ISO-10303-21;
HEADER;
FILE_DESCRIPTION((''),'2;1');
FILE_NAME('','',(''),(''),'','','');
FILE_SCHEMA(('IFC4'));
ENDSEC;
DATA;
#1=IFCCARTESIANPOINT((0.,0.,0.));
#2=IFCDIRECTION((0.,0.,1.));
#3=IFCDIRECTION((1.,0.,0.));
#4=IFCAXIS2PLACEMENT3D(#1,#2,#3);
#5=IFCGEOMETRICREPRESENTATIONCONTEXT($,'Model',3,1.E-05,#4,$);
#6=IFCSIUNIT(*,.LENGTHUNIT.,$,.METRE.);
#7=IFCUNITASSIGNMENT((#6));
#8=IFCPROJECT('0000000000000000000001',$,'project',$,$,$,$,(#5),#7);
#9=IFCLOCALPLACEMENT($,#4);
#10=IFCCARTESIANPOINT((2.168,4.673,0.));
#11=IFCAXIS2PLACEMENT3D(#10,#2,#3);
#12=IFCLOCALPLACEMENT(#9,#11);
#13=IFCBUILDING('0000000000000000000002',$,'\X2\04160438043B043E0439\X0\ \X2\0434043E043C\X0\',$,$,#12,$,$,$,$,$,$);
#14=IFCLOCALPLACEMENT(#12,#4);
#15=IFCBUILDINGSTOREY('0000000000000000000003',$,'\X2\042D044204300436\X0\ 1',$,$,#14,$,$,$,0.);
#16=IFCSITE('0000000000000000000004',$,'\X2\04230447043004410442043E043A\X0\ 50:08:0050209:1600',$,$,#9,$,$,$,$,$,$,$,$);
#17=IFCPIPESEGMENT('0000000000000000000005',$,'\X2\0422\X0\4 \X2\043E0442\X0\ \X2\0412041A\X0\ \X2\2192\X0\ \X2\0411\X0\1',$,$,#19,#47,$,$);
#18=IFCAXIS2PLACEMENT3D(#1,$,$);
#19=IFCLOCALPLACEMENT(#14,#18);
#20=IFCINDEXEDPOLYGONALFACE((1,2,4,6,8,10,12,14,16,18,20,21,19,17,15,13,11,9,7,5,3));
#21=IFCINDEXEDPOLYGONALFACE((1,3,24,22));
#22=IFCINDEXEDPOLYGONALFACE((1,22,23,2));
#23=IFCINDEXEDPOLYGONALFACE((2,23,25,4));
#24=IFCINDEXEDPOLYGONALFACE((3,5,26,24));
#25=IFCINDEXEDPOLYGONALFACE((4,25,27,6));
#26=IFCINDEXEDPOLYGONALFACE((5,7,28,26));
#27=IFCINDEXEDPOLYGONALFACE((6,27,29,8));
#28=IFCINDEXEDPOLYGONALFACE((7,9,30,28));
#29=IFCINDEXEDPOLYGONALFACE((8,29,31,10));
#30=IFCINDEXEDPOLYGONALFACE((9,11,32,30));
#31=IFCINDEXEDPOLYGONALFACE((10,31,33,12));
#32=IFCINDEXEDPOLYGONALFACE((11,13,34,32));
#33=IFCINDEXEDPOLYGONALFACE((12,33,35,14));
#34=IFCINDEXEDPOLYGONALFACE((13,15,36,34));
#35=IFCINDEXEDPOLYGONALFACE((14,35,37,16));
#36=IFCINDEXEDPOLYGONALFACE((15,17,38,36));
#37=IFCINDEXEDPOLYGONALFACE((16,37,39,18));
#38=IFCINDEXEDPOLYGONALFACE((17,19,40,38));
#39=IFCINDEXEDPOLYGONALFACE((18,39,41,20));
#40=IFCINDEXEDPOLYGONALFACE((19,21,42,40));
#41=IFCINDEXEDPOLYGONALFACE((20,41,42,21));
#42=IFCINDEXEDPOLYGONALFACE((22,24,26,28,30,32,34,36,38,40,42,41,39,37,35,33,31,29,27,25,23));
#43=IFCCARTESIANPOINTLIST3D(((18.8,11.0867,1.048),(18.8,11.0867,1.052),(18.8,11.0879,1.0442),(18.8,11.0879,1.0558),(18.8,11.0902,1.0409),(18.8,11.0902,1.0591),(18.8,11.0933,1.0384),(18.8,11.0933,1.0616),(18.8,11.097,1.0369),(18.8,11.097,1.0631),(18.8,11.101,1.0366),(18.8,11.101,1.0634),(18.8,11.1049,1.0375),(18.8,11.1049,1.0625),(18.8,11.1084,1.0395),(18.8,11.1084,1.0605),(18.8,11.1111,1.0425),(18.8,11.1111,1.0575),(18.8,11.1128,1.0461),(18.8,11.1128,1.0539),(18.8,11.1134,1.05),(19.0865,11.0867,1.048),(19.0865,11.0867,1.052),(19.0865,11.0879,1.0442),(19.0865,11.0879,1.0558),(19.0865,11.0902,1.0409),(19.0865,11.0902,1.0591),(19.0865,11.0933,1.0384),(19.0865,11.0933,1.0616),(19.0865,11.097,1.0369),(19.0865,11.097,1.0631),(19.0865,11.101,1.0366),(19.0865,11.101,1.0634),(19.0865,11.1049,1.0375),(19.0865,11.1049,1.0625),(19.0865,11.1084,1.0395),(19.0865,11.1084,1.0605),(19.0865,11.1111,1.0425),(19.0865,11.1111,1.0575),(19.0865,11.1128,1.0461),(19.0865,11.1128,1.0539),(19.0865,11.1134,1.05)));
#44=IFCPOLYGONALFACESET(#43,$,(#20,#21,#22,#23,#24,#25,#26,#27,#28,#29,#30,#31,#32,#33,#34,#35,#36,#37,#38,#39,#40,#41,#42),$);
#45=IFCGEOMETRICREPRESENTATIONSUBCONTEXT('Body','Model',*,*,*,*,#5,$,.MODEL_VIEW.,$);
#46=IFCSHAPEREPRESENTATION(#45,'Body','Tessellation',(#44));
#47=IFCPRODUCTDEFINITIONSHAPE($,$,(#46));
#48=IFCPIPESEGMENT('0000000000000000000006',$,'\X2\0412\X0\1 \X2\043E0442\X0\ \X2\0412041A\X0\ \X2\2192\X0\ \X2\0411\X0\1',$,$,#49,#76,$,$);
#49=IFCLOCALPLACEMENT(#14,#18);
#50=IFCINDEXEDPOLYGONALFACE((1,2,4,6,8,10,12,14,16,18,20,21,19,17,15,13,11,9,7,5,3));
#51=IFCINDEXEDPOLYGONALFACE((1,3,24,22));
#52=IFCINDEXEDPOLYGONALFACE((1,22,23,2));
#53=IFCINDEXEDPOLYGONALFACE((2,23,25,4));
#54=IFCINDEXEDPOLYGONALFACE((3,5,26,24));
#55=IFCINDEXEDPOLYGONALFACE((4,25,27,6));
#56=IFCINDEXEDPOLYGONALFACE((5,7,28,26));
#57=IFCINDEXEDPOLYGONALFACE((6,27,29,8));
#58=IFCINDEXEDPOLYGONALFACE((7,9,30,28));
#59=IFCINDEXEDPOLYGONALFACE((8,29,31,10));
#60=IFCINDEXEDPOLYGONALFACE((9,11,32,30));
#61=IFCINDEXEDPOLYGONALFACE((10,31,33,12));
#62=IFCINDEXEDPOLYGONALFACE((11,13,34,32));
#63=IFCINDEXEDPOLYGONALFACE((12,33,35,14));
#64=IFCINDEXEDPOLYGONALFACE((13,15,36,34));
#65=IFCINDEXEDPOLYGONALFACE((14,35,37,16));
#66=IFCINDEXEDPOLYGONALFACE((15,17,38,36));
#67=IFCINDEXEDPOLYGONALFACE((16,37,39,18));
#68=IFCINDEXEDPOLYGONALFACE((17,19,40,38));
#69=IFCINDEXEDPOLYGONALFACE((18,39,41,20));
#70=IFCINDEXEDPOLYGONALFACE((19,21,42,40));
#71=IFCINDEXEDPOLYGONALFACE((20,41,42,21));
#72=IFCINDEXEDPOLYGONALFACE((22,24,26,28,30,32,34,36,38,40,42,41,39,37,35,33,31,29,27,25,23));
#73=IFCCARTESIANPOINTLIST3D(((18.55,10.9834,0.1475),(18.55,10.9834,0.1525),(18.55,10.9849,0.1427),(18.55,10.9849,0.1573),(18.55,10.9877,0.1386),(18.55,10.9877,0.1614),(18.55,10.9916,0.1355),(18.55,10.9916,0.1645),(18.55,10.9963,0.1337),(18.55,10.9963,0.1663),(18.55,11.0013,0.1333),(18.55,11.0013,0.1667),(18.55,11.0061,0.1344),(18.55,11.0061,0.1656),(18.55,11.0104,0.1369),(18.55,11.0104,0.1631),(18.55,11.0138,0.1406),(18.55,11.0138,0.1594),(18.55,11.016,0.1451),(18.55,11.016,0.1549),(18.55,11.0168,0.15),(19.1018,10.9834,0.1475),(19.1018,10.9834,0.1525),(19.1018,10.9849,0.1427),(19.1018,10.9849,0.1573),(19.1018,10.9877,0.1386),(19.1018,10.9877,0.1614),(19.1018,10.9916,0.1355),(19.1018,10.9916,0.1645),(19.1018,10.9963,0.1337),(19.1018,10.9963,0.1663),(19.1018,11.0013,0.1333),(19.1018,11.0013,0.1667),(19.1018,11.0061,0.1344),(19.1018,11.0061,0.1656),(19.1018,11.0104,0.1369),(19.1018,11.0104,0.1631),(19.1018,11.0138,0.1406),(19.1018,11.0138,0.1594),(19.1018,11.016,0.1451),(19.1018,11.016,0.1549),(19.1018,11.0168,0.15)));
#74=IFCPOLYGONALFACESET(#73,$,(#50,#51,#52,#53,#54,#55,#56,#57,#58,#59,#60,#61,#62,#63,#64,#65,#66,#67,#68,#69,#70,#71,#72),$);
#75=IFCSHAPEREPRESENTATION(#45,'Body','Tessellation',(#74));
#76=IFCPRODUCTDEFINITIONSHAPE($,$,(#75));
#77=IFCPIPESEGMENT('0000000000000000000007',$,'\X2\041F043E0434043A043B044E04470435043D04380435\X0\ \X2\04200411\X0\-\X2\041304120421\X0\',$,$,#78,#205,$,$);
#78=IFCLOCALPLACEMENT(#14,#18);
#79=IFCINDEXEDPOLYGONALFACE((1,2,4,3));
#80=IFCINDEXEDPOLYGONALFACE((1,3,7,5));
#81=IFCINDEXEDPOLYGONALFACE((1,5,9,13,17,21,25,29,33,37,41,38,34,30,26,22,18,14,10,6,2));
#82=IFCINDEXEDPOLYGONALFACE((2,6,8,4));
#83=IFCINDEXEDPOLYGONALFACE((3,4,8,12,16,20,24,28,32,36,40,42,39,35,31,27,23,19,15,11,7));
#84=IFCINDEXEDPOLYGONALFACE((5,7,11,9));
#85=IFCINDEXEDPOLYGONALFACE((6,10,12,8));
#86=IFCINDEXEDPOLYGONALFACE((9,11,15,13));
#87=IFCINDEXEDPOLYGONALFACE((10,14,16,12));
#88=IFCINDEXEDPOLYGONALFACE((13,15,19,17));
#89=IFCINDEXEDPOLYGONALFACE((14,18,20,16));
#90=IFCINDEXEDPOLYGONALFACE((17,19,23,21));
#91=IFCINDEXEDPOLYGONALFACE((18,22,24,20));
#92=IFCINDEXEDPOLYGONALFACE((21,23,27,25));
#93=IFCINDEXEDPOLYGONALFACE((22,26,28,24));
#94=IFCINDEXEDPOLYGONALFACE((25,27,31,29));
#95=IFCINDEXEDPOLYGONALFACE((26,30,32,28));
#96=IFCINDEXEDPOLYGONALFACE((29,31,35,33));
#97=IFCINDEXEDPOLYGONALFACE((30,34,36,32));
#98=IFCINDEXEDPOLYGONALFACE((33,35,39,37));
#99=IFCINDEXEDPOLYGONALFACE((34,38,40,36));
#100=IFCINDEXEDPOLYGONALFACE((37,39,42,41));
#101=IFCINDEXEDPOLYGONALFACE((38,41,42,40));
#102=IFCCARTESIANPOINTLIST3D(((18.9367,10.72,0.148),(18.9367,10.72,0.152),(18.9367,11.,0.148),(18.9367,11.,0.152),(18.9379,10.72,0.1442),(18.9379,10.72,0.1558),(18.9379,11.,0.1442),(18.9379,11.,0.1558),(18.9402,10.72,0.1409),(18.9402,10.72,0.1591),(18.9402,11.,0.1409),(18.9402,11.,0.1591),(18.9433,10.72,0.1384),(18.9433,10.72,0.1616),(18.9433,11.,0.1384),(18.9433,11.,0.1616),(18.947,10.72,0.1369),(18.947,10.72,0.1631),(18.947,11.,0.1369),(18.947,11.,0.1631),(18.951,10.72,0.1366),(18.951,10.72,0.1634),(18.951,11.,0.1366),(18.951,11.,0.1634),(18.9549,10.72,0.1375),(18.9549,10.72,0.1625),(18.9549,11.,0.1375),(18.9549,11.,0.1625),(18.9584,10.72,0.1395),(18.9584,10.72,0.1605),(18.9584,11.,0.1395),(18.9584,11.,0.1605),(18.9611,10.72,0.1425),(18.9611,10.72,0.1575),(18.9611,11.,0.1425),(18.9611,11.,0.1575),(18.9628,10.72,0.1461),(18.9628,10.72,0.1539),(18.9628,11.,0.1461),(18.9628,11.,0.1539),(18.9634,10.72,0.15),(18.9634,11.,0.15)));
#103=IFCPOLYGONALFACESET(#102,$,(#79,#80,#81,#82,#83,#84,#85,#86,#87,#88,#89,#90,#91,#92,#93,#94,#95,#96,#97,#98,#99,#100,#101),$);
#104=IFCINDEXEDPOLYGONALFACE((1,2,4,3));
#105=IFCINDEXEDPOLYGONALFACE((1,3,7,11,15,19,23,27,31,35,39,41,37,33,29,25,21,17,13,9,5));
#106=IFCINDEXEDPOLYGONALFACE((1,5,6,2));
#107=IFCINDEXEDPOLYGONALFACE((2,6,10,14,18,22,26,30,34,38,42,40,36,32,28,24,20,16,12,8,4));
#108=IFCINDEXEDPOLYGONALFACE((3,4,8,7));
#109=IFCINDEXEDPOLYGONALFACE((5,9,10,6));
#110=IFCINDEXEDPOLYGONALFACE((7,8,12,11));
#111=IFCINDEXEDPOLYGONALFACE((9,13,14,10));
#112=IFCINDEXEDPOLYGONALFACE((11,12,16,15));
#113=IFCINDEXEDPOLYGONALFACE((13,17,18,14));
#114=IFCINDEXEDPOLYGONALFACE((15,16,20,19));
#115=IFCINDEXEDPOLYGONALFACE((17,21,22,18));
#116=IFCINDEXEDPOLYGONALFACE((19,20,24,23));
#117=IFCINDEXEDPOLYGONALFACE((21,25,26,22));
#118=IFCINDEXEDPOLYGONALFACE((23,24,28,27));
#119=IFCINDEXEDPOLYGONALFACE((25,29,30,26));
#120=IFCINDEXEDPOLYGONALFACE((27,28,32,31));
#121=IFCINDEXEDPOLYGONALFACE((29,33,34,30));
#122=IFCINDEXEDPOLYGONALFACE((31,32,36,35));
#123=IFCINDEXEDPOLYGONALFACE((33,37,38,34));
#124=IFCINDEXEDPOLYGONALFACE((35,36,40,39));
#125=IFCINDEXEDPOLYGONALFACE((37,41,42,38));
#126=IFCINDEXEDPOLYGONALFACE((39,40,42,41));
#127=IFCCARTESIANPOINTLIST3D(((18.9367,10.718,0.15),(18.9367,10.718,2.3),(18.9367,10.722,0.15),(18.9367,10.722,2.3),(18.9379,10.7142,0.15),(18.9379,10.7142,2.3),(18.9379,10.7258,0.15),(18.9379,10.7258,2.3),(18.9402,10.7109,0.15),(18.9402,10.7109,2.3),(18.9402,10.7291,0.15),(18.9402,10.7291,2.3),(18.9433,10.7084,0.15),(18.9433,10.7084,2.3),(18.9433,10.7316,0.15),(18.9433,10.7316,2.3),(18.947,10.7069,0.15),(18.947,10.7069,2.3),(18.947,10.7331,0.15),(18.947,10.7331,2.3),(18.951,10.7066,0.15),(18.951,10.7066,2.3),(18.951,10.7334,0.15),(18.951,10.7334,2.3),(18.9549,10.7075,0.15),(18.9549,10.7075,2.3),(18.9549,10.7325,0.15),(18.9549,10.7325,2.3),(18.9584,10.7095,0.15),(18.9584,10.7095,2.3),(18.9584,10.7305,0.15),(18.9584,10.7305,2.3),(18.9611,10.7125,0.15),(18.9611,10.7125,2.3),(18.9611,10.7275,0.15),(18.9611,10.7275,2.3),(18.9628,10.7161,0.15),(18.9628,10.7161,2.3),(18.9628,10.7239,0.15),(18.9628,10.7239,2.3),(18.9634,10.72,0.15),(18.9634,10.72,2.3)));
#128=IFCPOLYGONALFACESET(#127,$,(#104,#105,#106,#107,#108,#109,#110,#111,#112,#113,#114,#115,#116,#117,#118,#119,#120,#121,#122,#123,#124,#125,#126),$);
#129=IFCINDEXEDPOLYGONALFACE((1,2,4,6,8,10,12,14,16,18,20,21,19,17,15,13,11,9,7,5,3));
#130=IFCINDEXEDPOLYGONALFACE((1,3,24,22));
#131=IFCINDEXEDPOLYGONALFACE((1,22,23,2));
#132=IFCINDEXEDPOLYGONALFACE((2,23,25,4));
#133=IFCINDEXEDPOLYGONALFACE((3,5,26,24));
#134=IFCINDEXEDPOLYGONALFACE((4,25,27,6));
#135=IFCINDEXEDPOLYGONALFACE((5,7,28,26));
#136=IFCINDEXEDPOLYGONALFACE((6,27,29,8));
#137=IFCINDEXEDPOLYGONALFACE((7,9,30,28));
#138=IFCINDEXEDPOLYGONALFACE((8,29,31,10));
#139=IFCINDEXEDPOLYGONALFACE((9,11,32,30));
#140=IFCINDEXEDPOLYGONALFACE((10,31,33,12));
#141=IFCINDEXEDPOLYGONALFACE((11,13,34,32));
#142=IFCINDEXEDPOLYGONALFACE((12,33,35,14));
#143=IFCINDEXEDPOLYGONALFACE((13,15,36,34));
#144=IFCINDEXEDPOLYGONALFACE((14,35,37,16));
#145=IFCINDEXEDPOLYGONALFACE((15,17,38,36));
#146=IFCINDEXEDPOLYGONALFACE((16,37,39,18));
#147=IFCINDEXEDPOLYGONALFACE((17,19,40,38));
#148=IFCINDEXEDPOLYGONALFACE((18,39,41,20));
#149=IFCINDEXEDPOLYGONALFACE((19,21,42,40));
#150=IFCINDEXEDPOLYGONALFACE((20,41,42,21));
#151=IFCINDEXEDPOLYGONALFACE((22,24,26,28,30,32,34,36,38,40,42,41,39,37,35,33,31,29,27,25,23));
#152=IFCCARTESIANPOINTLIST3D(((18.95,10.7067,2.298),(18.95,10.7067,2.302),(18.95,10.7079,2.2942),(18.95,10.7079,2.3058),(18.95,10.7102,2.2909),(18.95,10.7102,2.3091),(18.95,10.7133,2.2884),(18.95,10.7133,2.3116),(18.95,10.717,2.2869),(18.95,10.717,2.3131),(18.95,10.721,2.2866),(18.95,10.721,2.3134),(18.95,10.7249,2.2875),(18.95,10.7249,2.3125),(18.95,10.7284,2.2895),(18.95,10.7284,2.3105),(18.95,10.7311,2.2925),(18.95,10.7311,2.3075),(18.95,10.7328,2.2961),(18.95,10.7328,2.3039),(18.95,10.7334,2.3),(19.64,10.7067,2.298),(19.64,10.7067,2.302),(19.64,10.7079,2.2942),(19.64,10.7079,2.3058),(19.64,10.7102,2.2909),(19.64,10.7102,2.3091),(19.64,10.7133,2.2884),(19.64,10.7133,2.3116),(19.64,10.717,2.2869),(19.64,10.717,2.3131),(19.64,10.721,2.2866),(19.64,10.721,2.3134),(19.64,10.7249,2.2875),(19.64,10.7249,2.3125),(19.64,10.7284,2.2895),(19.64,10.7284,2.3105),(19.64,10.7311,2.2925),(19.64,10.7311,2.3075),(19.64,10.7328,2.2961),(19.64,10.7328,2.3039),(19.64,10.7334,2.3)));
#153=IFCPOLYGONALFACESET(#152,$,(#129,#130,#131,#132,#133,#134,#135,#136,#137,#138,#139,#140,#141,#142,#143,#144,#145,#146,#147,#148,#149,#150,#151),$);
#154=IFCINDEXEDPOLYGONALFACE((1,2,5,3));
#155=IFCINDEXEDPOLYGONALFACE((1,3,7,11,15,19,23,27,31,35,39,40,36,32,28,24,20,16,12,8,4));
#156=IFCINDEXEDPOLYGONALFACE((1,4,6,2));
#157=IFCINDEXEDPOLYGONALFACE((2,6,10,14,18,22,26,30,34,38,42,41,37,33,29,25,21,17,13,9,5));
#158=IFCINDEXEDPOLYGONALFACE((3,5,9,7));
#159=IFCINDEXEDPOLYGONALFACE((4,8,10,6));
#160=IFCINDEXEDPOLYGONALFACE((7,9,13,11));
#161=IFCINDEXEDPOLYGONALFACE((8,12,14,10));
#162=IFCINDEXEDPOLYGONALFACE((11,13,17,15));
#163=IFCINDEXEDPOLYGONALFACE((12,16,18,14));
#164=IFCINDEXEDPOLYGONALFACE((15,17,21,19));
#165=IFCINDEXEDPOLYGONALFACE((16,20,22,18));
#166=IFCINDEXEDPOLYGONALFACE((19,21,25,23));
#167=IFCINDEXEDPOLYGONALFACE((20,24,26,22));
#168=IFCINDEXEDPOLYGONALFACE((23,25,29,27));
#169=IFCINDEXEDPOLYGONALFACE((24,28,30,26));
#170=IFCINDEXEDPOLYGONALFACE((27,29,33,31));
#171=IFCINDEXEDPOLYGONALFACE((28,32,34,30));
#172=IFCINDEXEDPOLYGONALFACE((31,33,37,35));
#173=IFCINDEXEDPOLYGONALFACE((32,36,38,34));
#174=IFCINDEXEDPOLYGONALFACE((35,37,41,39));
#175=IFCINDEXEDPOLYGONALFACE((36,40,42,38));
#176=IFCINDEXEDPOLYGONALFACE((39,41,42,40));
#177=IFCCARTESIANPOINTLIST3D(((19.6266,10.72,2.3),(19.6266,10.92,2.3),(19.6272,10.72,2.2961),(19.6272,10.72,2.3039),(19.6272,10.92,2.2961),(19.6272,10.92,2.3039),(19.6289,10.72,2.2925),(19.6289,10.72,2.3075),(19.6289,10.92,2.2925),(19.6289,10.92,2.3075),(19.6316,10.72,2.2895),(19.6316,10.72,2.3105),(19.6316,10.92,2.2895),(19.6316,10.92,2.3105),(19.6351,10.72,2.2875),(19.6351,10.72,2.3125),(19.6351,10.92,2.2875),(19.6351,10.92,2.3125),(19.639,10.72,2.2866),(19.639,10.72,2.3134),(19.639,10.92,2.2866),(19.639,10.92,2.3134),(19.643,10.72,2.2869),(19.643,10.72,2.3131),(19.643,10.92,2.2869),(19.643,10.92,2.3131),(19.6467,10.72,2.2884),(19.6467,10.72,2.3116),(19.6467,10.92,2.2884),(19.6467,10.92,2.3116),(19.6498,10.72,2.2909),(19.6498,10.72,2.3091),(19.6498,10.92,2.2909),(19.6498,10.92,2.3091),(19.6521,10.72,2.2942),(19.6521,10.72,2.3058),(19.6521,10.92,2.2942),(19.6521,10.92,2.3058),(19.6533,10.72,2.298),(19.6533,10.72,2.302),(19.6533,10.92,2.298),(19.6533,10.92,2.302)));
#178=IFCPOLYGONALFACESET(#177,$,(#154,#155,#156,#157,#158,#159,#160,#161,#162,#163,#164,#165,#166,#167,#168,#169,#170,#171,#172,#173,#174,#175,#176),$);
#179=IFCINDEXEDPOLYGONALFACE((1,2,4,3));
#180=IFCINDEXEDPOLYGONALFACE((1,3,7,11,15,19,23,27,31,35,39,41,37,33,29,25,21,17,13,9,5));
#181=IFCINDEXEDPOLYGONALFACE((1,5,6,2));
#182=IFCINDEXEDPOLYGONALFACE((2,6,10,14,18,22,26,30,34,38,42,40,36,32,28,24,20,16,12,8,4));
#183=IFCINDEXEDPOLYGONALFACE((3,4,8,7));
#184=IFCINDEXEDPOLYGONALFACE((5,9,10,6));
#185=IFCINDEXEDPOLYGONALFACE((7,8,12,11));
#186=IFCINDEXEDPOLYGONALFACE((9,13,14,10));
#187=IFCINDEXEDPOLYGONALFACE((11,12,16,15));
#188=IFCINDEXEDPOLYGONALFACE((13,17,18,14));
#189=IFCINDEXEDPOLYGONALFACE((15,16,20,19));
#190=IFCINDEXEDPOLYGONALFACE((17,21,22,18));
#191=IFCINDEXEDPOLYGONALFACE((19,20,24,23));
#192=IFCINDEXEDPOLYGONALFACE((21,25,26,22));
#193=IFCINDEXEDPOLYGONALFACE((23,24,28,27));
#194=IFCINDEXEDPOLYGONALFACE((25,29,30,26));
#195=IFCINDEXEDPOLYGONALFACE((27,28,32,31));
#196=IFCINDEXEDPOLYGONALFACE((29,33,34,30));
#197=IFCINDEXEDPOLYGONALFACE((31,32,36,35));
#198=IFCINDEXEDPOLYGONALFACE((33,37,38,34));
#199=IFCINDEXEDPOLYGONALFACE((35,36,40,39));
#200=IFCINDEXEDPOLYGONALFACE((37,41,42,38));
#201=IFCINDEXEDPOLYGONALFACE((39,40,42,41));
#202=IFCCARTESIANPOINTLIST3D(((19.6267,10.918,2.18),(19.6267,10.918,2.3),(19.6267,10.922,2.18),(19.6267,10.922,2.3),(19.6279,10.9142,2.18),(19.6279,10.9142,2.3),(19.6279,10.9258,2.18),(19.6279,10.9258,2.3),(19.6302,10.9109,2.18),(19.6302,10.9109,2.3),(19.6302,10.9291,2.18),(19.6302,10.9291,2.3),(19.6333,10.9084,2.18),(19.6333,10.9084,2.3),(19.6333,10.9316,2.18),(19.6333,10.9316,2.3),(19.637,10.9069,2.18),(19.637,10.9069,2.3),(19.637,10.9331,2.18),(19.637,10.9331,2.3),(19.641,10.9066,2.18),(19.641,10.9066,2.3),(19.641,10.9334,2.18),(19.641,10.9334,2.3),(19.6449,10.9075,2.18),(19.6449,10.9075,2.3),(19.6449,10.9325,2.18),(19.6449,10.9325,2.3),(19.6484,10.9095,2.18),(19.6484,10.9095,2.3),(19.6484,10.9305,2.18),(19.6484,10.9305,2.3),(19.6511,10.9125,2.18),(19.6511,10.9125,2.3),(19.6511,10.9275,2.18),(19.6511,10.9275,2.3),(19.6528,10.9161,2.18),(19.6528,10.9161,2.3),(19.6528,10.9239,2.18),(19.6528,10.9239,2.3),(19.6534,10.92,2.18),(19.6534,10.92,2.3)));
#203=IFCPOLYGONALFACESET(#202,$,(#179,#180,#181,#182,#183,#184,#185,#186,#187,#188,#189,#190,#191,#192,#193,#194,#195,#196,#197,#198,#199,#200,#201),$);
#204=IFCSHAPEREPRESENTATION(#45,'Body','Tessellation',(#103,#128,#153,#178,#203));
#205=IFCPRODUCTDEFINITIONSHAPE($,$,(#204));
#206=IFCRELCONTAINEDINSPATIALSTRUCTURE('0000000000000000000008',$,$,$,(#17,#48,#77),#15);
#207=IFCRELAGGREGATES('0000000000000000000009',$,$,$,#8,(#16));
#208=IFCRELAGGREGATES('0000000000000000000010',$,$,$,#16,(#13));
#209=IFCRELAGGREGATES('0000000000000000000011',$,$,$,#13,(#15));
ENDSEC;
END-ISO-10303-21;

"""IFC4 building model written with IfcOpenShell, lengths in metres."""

from ifc_helpers import new_model, si_unit, frame, origin_with_axes, origin_2d, place, context, subcontext, project, spatial, circle, extrude, element, save


model = new_model("IFC4")

# Units and contexts
model_context = context("Model", 3, precision=1e-05, world=origin_with_axes())
body_context = subcontext(model_context, "Body", "Model", "MODEL_VIEW")
ifc_project = project(units=[si_unit("LENGTHUNIT", "METRE")], contexts=[model_context])

# Site, building, storey
site_placement = place(None, origin_with_axes())
site = spatial("IfcSite", under=ifc_project, at=site_placement, Name="Участок 50:08:0050209:1600")
building_placement = place(site_placement, frame((2.168, 4.673, 0.0), z_axis=(0.0, 0.0, 1.0), x_axis=(1.0, 0.0, 0.0)))
building = spatial("IfcBuilding", under=site, at=building_placement, Name="Жилой дом")
storey_placement = place(building_placement, origin_with_axes())
storey = spatial("IfcBuildingStorey", under=building, at=storey_placement, Name="Этаж 1", Elevation=0.0)

# Pipe segments
pipe_segment_1_placement = place(storey_placement, origin_with_axes())
element("IfcPipeSegment", 1, at=pipe_segment_1_placement, inside=storey, Name="Т4 от ВК → Б1", context=body_context, shape_type="SweptSolid", body=[
    extrude(circle(Radius=0.0134, at=origin_2d()), frame((18.8, 11.1, 1.05), z_axis=(1.0, 0.0, 0.0), x_axis=(0.0, 1.0, 0.0)), (0.0, 0.0, 1.0), 0.2865),
])
pipe_segment_2_placement = place(storey_placement, origin_with_axes())
element("IfcPipeSegment", 2, at=pipe_segment_2_placement, inside=storey, Name="В1 от ВК → Б1", context=body_context, shape_type="SweptSolid", body=[
    extrude(circle(Radius=0.0168, at=origin_2d()), frame((18.55, 11.0, 0.15), z_axis=(1.0, 0.0, 0.0), x_axis=(0.0, 1.0, 0.0)), (0.0, 0.0, 1.0), 0.5518),
])
pipe_segment_3_placement = place(storey_placement, origin_with_axes())
element("IfcPipeSegment", 3, at=pipe_segment_3_placement, inside=storey, Name="Подключение РБ-ГВС", context=body_context, shape_type="SweptSolid", body=[
    extrude(circle(Radius=0.0134, at=origin_2d()), frame((18.95, 11.0, 0.15), z_axis=(0.0, -1.0, 0.0), x_axis=(1.0, 0.0, 0.0)), (0.0, 0.0, 1.0), 0.28),
    extrude(circle(Radius=0.0134, at=origin_2d()), frame((18.95, 10.72, 0.15), z_axis=(0.0, 0.0, 1.0), x_axis=(1.0, 0.0, 0.0)), (0.0, 0.0, 1.0), 2.15),
    extrude(circle(Radius=0.0134, at=origin_2d()), frame((18.95, 10.72, 2.3), z_axis=(1.0, 0.0, 0.0), x_axis=(0.0, 1.0, 0.0)), (0.0, 0.0, 1.0), 0.69),
    extrude(circle(Radius=0.0134, at=origin_2d()), frame((19.64, 10.72, 2.3), z_axis=(0.0, 1.0, 0.0), x_axis=(-1.0, 0.0, 0.0)), (0.0, 0.0, 1.0), 0.2),
    extrude(circle(Radius=0.0134, at=origin_2d()), frame((19.64, 10.92, 2.3), z_axis=(0.0, 0.0, -1.0), x_axis=(1.0, 0.0, 0.0)), (0.0, 0.0, 1.0), 0.12),
])

save(model, "model.ifc")
